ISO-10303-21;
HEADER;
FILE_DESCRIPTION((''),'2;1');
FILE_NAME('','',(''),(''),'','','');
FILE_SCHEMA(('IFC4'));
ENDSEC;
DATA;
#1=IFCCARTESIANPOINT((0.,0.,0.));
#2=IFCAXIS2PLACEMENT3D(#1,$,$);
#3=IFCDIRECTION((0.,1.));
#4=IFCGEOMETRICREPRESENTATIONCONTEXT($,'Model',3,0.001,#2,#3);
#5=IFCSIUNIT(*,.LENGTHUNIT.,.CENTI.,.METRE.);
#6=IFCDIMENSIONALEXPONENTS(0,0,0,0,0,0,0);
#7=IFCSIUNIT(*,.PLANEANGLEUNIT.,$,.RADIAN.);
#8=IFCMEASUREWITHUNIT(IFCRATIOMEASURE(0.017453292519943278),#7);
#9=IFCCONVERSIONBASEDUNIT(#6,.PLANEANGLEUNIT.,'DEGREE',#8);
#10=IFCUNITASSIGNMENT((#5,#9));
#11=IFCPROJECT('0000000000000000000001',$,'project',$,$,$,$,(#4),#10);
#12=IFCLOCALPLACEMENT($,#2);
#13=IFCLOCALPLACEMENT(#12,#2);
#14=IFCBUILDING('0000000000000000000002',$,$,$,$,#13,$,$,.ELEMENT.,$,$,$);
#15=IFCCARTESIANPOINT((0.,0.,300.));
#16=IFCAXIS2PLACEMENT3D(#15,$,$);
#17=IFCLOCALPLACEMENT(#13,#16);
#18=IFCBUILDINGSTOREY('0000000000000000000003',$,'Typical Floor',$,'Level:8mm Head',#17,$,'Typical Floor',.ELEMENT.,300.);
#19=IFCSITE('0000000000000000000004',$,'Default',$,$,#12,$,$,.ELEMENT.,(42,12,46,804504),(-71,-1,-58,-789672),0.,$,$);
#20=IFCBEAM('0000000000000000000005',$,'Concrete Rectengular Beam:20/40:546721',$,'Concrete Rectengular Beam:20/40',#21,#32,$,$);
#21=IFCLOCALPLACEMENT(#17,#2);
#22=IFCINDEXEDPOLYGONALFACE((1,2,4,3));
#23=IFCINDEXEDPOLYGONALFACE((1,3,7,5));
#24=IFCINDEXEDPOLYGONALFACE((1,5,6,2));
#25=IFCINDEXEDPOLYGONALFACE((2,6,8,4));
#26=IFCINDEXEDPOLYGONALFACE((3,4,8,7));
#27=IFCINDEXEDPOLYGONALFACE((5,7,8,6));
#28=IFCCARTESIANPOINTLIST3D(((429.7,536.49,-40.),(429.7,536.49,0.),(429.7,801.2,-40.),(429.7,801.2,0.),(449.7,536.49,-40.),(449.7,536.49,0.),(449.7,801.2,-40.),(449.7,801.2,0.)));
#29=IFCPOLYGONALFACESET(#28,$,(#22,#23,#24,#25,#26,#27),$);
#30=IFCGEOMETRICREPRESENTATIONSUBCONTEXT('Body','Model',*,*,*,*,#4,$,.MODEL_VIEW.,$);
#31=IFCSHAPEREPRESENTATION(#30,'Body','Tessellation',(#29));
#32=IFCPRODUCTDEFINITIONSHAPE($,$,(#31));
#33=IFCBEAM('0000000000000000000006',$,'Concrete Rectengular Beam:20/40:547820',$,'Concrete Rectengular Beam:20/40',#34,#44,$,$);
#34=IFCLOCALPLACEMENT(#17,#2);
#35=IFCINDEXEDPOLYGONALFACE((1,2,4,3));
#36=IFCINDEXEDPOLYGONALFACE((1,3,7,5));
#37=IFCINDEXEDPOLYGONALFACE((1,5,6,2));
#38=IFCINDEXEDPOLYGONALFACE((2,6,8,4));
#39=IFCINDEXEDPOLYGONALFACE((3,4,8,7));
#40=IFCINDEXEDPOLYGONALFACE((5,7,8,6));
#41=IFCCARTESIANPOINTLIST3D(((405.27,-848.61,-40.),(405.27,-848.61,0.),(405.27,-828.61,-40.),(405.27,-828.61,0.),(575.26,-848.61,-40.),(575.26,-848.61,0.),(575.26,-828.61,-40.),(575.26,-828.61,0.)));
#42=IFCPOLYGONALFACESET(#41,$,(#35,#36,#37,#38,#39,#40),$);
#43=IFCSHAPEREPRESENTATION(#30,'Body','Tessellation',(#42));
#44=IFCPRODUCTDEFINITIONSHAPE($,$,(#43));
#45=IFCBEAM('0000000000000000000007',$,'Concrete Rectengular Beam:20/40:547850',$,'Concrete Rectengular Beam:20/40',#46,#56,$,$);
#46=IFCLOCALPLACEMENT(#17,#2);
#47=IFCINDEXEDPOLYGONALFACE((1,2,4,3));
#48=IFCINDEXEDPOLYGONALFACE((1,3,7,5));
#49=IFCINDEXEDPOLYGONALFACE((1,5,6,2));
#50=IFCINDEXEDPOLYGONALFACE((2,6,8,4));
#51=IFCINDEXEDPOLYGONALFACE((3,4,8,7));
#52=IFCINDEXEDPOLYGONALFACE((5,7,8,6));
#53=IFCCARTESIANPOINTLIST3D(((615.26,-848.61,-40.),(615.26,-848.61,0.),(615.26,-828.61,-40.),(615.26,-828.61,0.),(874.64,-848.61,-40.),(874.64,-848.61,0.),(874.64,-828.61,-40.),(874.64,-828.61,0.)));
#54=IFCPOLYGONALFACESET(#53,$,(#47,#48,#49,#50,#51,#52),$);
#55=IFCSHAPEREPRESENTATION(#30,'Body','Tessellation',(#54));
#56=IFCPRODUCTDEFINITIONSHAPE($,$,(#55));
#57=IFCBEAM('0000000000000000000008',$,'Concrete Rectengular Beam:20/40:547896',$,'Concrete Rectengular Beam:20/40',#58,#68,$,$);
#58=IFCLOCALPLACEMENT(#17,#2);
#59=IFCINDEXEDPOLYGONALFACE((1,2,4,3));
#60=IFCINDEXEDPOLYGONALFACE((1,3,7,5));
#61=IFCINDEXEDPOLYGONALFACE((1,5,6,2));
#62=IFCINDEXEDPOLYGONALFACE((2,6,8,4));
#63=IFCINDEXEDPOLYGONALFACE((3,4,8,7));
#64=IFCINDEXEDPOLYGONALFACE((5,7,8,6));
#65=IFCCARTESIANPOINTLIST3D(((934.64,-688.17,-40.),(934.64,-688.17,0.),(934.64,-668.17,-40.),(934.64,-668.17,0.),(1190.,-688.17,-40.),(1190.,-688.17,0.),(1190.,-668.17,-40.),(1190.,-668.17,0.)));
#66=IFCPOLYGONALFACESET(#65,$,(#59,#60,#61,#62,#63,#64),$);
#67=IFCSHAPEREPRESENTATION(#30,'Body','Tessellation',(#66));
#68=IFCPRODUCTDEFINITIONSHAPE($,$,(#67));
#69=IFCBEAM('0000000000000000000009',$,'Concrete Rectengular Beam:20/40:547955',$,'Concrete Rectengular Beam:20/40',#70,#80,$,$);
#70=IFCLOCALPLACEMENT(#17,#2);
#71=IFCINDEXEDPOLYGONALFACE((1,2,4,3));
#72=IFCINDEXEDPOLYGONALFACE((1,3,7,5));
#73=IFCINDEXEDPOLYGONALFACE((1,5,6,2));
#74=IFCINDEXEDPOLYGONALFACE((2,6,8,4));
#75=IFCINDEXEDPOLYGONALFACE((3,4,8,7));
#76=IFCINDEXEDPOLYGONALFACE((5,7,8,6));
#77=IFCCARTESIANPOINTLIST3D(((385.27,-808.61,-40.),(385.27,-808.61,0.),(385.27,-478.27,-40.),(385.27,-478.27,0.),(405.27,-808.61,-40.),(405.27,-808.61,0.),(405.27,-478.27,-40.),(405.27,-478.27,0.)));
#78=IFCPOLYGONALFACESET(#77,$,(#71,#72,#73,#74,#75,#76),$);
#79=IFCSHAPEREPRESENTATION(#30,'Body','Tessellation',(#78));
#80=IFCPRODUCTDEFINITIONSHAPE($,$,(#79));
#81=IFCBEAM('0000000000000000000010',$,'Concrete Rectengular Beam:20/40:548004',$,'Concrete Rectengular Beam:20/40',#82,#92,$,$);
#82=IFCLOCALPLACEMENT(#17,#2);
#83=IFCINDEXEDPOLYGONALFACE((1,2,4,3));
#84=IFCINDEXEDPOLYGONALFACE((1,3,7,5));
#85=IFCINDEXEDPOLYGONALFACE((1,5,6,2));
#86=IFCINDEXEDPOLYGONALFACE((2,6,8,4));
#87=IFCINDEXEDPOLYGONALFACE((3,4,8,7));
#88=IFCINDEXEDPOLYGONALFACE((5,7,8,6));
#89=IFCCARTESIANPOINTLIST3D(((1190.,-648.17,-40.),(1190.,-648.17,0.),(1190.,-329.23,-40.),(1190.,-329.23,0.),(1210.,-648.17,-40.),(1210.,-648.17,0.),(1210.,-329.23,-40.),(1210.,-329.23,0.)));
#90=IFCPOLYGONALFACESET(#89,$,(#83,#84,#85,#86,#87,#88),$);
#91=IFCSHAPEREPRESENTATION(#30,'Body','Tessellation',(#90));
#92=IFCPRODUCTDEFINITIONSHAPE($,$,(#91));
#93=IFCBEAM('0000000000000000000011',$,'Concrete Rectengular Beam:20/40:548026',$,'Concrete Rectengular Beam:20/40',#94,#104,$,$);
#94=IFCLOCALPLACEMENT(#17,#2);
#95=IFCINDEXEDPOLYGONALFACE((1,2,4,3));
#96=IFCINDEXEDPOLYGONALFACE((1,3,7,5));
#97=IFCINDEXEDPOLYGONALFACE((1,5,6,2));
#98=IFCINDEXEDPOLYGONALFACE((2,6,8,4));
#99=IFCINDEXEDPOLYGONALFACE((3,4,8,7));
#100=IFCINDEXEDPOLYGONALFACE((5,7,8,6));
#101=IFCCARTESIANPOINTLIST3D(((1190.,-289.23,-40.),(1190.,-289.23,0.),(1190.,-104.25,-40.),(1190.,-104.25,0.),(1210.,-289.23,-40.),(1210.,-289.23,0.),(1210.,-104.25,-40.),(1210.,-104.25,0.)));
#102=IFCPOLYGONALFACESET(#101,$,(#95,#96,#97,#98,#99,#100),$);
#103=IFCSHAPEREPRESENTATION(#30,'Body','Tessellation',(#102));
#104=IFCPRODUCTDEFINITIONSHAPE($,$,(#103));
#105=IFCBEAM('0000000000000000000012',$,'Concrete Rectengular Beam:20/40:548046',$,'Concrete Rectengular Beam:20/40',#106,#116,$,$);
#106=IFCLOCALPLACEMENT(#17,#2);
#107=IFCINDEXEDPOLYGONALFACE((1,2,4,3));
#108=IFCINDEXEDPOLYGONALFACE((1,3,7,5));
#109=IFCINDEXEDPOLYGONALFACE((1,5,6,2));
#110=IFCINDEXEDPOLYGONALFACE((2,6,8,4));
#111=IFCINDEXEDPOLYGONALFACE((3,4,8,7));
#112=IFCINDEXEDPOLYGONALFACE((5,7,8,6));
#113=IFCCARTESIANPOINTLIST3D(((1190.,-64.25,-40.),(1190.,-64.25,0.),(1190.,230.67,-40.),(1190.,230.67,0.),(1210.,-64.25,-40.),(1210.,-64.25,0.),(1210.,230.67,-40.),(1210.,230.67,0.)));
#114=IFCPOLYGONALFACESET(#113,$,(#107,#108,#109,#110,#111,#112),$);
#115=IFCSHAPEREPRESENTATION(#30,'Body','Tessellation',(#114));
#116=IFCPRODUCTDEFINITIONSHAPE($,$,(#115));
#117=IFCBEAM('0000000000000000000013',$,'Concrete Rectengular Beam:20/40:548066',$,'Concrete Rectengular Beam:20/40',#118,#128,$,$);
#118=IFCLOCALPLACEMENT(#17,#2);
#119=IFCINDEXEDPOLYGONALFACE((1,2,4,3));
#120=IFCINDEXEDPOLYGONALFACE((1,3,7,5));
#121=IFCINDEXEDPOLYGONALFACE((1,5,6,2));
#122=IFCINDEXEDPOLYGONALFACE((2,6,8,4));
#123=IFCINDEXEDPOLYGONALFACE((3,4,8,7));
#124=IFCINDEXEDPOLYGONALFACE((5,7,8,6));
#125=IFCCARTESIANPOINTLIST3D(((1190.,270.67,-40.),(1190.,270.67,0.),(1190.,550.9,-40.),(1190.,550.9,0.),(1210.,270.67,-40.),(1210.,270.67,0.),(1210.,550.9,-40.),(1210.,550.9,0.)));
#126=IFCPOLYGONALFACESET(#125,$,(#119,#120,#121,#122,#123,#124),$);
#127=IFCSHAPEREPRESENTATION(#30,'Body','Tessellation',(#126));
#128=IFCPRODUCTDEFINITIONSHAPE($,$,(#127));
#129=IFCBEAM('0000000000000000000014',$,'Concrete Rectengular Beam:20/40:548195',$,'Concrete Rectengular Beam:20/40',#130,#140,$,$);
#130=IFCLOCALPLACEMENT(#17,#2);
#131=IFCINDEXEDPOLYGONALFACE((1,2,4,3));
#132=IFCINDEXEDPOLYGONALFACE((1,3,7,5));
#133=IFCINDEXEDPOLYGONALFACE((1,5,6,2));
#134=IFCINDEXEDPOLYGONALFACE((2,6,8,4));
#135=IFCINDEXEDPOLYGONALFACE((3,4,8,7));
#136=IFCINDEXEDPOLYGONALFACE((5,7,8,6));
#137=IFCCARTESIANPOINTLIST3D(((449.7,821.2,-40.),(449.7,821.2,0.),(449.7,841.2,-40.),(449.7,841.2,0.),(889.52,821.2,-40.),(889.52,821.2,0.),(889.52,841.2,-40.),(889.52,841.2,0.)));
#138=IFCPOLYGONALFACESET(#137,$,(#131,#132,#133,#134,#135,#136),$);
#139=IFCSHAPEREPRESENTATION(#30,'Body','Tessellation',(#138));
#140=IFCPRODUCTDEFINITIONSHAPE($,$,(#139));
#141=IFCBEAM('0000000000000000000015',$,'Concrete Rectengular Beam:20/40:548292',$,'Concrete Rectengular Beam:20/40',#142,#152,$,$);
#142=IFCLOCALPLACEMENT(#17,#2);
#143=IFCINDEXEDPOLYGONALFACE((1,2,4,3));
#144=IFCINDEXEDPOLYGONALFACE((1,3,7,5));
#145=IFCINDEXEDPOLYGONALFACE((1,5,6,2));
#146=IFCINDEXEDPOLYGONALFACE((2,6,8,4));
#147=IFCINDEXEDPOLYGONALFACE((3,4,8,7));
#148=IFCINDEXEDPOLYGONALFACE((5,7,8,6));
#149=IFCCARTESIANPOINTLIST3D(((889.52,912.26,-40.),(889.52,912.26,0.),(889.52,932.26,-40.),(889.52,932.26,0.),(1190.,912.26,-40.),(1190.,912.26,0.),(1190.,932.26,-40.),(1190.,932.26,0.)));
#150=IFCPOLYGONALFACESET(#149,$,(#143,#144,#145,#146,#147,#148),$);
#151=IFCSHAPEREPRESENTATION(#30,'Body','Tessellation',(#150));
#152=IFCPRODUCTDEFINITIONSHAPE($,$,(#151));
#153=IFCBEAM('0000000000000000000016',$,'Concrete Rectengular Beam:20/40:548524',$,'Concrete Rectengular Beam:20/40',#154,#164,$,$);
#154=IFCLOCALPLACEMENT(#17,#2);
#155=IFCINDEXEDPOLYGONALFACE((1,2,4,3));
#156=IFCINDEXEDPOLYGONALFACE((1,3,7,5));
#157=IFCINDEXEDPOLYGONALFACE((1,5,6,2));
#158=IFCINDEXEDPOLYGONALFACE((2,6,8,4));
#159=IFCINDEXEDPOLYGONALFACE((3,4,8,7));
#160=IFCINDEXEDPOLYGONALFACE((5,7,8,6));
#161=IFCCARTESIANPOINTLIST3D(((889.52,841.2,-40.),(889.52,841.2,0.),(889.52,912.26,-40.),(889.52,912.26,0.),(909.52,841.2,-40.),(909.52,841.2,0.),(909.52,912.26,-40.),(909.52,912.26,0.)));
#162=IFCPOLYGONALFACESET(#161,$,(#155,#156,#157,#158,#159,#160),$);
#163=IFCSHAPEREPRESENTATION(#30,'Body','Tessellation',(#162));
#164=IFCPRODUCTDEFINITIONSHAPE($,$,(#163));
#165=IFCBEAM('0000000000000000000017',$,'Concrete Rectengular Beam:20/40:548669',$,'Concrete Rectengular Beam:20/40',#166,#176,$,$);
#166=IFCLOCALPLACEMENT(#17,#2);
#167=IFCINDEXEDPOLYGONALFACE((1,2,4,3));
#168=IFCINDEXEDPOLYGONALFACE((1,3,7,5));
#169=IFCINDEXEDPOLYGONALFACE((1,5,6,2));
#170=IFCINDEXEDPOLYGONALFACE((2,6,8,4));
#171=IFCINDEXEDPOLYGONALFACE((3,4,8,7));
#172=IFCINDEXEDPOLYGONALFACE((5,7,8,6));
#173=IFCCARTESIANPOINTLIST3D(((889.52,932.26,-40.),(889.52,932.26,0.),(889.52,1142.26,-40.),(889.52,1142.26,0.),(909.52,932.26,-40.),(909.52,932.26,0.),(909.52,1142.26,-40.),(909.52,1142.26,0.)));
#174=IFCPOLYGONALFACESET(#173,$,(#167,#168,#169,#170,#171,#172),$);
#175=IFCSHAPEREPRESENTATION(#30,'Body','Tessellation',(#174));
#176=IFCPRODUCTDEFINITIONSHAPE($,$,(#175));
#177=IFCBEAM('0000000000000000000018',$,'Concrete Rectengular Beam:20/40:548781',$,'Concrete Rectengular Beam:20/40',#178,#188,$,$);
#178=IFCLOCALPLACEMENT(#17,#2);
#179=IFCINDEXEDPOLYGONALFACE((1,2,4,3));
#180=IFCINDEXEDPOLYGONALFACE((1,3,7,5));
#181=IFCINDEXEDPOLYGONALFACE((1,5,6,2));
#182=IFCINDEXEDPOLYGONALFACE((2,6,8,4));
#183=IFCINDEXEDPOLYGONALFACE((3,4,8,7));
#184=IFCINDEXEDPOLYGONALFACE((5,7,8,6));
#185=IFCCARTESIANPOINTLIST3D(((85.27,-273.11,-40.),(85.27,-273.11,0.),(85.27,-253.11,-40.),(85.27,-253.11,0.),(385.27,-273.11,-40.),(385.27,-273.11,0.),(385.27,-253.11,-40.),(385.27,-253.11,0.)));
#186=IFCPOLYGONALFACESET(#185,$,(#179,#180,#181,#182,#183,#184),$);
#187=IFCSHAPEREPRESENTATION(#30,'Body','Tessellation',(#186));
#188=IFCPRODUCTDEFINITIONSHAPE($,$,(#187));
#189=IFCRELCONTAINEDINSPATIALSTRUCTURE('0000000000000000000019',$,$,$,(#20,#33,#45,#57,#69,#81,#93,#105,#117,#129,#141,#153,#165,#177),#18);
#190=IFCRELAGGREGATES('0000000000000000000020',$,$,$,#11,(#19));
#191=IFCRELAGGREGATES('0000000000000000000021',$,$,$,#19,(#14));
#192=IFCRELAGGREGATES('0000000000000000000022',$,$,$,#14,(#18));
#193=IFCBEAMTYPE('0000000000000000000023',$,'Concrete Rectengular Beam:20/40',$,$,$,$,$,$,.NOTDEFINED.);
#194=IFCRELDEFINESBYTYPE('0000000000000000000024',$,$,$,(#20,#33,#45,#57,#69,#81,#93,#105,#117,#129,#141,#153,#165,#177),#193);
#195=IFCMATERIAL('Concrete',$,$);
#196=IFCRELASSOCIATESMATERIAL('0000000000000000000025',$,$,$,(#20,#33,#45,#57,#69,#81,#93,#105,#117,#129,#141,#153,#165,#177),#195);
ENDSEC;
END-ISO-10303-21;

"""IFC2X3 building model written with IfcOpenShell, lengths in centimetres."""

from ifc_helpers import new_model, entity, si_unit, converted_unit, direction, frame, frame_2d, origin, place, context, subcontext, project, spatial, rectangle, extrude, material, type_object, element, save


model = new_model("IFC2X3")

# Units and contexts
model_context = context("Model", 3, precision=0.001, world=origin(), true_north=direction((0.0, 1.0)))
body_context = subcontext(model_context, "Body", "Model", "MODEL_VIEW")
ifc_project = project(units=[si_unit("LENGTHUNIT", "METRE", prefix="CENTI"), converted_unit("PLANEANGLEUNIT", "DEGREE", entity("IfcRatioMeasure", 0.017453292519943278), si_unit("PLANEANGLEUNIT", "RADIAN"), dimensions=[0, 0, 0, 0, 0, 0, 0])], contexts=[model_context])

# Site, building, storey
site_placement = place(None, origin())
site = spatial("IfcSite", under=ifc_project, at=site_placement, Name="Default", CompositionType="ELEMENT", RefLatitude=(42, 12, 46, 804504), RefLongitude=(-71, -1, -58, -789672), RefElevation=0.0)
building_placement = place(site_placement, origin())
building = spatial("IfcBuilding", under=site, at=building_placement, CompositionType="ELEMENT")
storey_placement = place(building_placement, frame((0.0, 0.0, 300.0)))
storey = spatial("IfcBuildingStorey", under=building, at=storey_placement, Name="Typical Floor", ObjectType="Level:8mm Head", LongName="Typical Floor", CompositionType="ELEMENT", Elevation=300.0)

# Beams
ifc_material = material(Name="Concrete")
beam_type = type_object("IfcBeamType", Name="Concrete Rectengular Beam:20/40", PredefinedType="NOTDEFINED")
beam_1_placement = place(storey_placement, frame((439.7, 516.49, 0.0), z_axis=(0.0, 0.0, 1.0), x_axis=(0.0, 1.0, 0.0)))
element("IfcBeam", 1, at=beam_1_placement, inside=storey, type_object=beam_type, material=ifc_material, Name="Concrete Rectengular Beam:20/40:546721", ObjectType="Concrete Rectengular Beam:20/40", context=body_context, shape_type="SweptSolid", body=[
    extrude(rectangle(XDim=40.0, YDim=20.0, at=frame_2d((0.0, 0.0), x_axis=(1.0, 0.0))), frame((20.0, 0.0, -20.0), z_axis=(1.0, 0.0, 0.0), x_axis=(0.0, 0.0, -1.0)), (0.0, 0.0, 1.0), 264.71),
])
beam_2_placement = place(storey_placement, frame((595.26, -838.61, 0.0), z_axis=(0.0, 0.0, 1.0), x_axis=(-1.0, 0.0, 0.0)))
element("IfcBeam", 2, at=beam_2_placement, inside=storey, type_object=beam_type, material=ifc_material, Name="Concrete Rectengular Beam:20/40:547820", ObjectType="Concrete Rectengular Beam:20/40", context=body_context, shape_type="SweptSolid", body=[
    extrude(rectangle(XDim=40.0, YDim=20.0, at=frame_2d((0.0, 0.0), x_axis=(1.0, 0.0))), frame((20.0, 0.0, -20.0), z_axis=(1.0, 0.0, 0.0), x_axis=(0.0, 0.0, -1.0)), (0.0, 0.0, 1.0), 169.99),
])
beam_3_placement = place(storey_placement, frame((595.26, -838.61, 0.0)))
element("IfcBeam", 3, at=beam_3_placement, inside=storey, type_object=beam_type, material=ifc_material, Name="Concrete Rectengular Beam:20/40:547850", ObjectType="Concrete Rectengular Beam:20/40", context=body_context, shape_type="SweptSolid", body=[
    extrude(rectangle(XDim=40.0, YDim=20.0, at=frame_2d((0.0, 0.0), x_axis=(1.0, 0.0))), frame((20.0, 0.0, -20.0), z_axis=(1.0, 0.0, 0.0), x_axis=(0.0, 0.0, -1.0)), (0.0, 0.0, 1.0), 259.38),
])
beam_4_placement = place(storey_placement, frame((914.64, -678.17, 0.0)))
element("IfcBeam", 4, at=beam_4_placement, inside=storey, type_object=beam_type, material=ifc_material, Name="Concrete Rectengular Beam:20/40:547896", ObjectType="Concrete Rectengular Beam:20/40", context=body_context, shape_type="SweptSolid", body=[
    extrude(rectangle(XDim=40.0, YDim=20.0, at=frame_2d((0.0, 0.0), x_axis=(1.0, 0.0))), frame((20.0, 0.0, -20.0), z_axis=(1.0, 0.0, 0.0), x_axis=(0.0, 0.0, -1.0)), (0.0, 0.0, 1.0), 255.36),
])
beam_5_placement = place(storey_placement, frame((395.27, -828.61, 0.0), z_axis=(0.0, 0.0, 1.0), x_axis=(0.0, 1.0, 0.0)))
element("IfcBeam", 5, at=beam_5_placement, inside=storey, type_object=beam_type, material=ifc_material, Name="Concrete Rectengular Beam:20/40:547955", ObjectType="Concrete Rectengular Beam:20/40", context=body_context, shape_type="SweptSolid", body=[
    extrude(rectangle(XDim=40.0, YDim=20.0, at=frame_2d((0.0, 0.0), x_axis=(1.0, 0.0))), frame((20.0, 0.0, -20.0), z_axis=(1.0, 0.0, 0.0), x_axis=(0.0, 0.0, -1.0)), (0.0, 0.0, 1.0), 330.35),
])
beam_6_placement = place(storey_placement, frame((1200.0, -668.17, 0.0), z_axis=(0.0, 0.0, 1.0), x_axis=(0.0, 1.0, 0.0)))
element("IfcBeam", 6, at=beam_6_placement, inside=storey, type_object=beam_type, material=ifc_material, Name="Concrete Rectengular Beam:20/40:548004", ObjectType="Concrete Rectengular Beam:20/40", context=body_context, shape_type="SweptSolid", body=[
    extrude(rectangle(XDim=40.0, YDim=20.0, at=frame_2d((0.0, 0.0), x_axis=(1.0, 0.0))), frame((20.0, 0.0, -20.0), z_axis=(1.0, 0.0, 0.0), x_axis=(0.0, 0.0, -1.0)), (0.0, 0.0, 1.0), 318.95),
])
beam_7_placement = place(storey_placement, frame((1200.0, -309.23, 0.0), z_axis=(0.0, 0.0, 1.0), x_axis=(0.0, 1.0, 0.0)))
element("IfcBeam", 7, at=beam_7_placement, inside=storey, type_object=beam_type, material=ifc_material, Name="Concrete Rectengular Beam:20/40:548026", ObjectType="Concrete Rectengular Beam:20/40", context=body_context, shape_type="SweptSolid", body=[
    extrude(rectangle(XDim=40.0, YDim=20.0, at=frame_2d((0.0, 0.0), x_axis=(1.0, 0.0))), frame((20.0, 0.0, -20.0), z_axis=(1.0, 0.0, 0.0), x_axis=(0.0, 0.0, -1.0)), (0.0, 0.0, 1.0), 184.97),
])
beam_8_placement = place(storey_placement, frame((1200.0, -84.25, 0.0), z_axis=(0.0, 0.0, 1.0), x_axis=(0.0, 1.0, 0.0)))
element("IfcBeam", 8, at=beam_8_placement, inside=storey, type_object=beam_type, material=ifc_material, Name="Concrete Rectengular Beam:20/40:548046", ObjectType="Concrete Rectengular Beam:20/40", context=body_context, shape_type="SweptSolid", body=[
    extrude(rectangle(XDim=40.0, YDim=20.0, at=frame_2d((0.0, 0.0), x_axis=(1.0, 0.0))), frame((20.0, 0.0, -20.0), z_axis=(1.0, 0.0, 0.0), x_axis=(0.0, 0.0, -1.0)), (0.0, 0.0, 1.0), 294.92),
])
beam_9_placement = place(storey_placement, frame((1200.0, 250.67, 0.0), z_axis=(0.0, 0.0, 1.0), x_axis=(0.0, 1.0, 0.0)))
element("IfcBeam", 9, at=beam_9_placement, inside=storey, type_object=beam_type, material=ifc_material, Name="Concrete Rectengular Beam:20/40:548066", ObjectType="Concrete Rectengular Beam:20/40", context=body_context, shape_type="SweptSolid", body=[
    extrude(rectangle(XDim=40.0, YDim=20.0, at=frame_2d((0.0, 0.0), x_axis=(1.0, 0.0))), frame((20.0, 0.0, -20.0), z_axis=(1.0, 0.0, 0.0), x_axis=(0.0, 0.0, -1.0)), (0.0, 0.0, 1.0), 280.23),
])
beam_10_placement = place(storey_placement, frame((899.52, 831.2, 0.0), z_axis=(0.0, 0.0, 1.0), x_axis=(-1.0, 0.0, 0.0)))
element("IfcBeam", 10, at=beam_10_placement, inside=storey, type_object=beam_type, material=ifc_material, Name="Concrete Rectengular Beam:20/40:548195", ObjectType="Concrete Rectengular Beam:20/40", context=body_context, shape_type="SweptSolid", body=[
    extrude(rectangle(XDim=40.0, YDim=20.0, at=frame_2d((0.0, 0.0), x_axis=(1.0, 0.0))), frame((10.0, 0.0, -20.0), z_axis=(1.0, 0.0, 0.0), x_axis=(0.0, 0.0, -1.0)), (0.0, 0.0, 1.0), 439.81),
])
beam_11_placement = place(storey_placement, frame((899.52, 922.26, 0.0)))
element("IfcBeam", 11, at=beam_11_placement, inside=storey, type_object=beam_type, material=ifc_material, Name="Concrete Rectengular Beam:20/40:548292", ObjectType="Concrete Rectengular Beam:20/40", context=body_context, shape_type="SweptSolid", body=[
    extrude(rectangle(XDim=40.0, YDim=20.0, at=frame_2d((0.0, 0.0), x_axis=(1.0, 0.0))), frame((-10.0, 0.0, -20.0), z_axis=(1.0, 0.0, 0.0), x_axis=(0.0, 0.0, -1.0)), (0.0, 0.0, 1.0), 300.49),
])
beam_12_placement = place(storey_placement, frame((899.52, 831.2, 0.0), z_axis=(0.0, 0.0, 1.0), x_axis=(0.0, 1.0, 0.0)))
element("IfcBeam", 12, at=beam_12_placement, inside=storey, type_object=beam_type, material=ifc_material, Name="Concrete Rectengular Beam:20/40:548524", ObjectType="Concrete Rectengular Beam:20/40", context=body_context, shape_type="SweptSolid", body=[
    extrude(rectangle(XDim=40.0, YDim=20.0, at=frame_2d((0.0, 0.0), x_axis=(1.0, 0.0))), frame((10.0, 0.0, -20.0), z_axis=(1.0, 0.0, 0.0), x_axis=(0.0, 0.0, -1.0)), (0.0, 0.0, 1.0), 71.06),
])
beam_13_placement = place(storey_placement, frame((899.52, 922.26, 0.0), z_axis=(0.0, 0.0, 1.0), x_axis=(0.0, 1.0, 0.0)))
element("IfcBeam", 13, at=beam_13_placement, inside=storey, type_object=beam_type, material=ifc_material, Name="Concrete Rectengular Beam:20/40:548669", ObjectType="Concrete Rectengular Beam:20/40", context=body_context, shape_type="SweptSolid", body=[
    extrude(rectangle(XDim=40.0, YDim=20.0, at=frame_2d((0.0, 0.0), x_axis=(1.0, 0.0))), frame((10.0, 0.0, -20.0), z_axis=(1.0, 0.0, 0.0), x_axis=(0.0, 0.0, -1.0)), (0.0, 0.0, 1.0), 210.0),
])
beam_14_placement = place(storey_placement, frame((65.27, -263.11, 0.0)))
element("IfcBeam", 14, at=beam_14_placement, inside=storey, type_object=beam_type, material=ifc_material, Name="Concrete Rectengular Beam:20/40:548781", ObjectType="Concrete Rectengular Beam:20/40", context=body_context, shape_type="SweptSolid", body=[
    extrude(rectangle(XDim=40.0, YDim=20.0, at=frame_2d((0.0, 0.0), x_axis=(1.0, 0.0))), frame((20.0, 0.0, -20.0), z_axis=(1.0, 0.0, 0.0), x_axis=(0.0, 0.0, -1.0)), (0.0, 0.0, 1.0), 300.0),
])

save(model, "model.ifc")
